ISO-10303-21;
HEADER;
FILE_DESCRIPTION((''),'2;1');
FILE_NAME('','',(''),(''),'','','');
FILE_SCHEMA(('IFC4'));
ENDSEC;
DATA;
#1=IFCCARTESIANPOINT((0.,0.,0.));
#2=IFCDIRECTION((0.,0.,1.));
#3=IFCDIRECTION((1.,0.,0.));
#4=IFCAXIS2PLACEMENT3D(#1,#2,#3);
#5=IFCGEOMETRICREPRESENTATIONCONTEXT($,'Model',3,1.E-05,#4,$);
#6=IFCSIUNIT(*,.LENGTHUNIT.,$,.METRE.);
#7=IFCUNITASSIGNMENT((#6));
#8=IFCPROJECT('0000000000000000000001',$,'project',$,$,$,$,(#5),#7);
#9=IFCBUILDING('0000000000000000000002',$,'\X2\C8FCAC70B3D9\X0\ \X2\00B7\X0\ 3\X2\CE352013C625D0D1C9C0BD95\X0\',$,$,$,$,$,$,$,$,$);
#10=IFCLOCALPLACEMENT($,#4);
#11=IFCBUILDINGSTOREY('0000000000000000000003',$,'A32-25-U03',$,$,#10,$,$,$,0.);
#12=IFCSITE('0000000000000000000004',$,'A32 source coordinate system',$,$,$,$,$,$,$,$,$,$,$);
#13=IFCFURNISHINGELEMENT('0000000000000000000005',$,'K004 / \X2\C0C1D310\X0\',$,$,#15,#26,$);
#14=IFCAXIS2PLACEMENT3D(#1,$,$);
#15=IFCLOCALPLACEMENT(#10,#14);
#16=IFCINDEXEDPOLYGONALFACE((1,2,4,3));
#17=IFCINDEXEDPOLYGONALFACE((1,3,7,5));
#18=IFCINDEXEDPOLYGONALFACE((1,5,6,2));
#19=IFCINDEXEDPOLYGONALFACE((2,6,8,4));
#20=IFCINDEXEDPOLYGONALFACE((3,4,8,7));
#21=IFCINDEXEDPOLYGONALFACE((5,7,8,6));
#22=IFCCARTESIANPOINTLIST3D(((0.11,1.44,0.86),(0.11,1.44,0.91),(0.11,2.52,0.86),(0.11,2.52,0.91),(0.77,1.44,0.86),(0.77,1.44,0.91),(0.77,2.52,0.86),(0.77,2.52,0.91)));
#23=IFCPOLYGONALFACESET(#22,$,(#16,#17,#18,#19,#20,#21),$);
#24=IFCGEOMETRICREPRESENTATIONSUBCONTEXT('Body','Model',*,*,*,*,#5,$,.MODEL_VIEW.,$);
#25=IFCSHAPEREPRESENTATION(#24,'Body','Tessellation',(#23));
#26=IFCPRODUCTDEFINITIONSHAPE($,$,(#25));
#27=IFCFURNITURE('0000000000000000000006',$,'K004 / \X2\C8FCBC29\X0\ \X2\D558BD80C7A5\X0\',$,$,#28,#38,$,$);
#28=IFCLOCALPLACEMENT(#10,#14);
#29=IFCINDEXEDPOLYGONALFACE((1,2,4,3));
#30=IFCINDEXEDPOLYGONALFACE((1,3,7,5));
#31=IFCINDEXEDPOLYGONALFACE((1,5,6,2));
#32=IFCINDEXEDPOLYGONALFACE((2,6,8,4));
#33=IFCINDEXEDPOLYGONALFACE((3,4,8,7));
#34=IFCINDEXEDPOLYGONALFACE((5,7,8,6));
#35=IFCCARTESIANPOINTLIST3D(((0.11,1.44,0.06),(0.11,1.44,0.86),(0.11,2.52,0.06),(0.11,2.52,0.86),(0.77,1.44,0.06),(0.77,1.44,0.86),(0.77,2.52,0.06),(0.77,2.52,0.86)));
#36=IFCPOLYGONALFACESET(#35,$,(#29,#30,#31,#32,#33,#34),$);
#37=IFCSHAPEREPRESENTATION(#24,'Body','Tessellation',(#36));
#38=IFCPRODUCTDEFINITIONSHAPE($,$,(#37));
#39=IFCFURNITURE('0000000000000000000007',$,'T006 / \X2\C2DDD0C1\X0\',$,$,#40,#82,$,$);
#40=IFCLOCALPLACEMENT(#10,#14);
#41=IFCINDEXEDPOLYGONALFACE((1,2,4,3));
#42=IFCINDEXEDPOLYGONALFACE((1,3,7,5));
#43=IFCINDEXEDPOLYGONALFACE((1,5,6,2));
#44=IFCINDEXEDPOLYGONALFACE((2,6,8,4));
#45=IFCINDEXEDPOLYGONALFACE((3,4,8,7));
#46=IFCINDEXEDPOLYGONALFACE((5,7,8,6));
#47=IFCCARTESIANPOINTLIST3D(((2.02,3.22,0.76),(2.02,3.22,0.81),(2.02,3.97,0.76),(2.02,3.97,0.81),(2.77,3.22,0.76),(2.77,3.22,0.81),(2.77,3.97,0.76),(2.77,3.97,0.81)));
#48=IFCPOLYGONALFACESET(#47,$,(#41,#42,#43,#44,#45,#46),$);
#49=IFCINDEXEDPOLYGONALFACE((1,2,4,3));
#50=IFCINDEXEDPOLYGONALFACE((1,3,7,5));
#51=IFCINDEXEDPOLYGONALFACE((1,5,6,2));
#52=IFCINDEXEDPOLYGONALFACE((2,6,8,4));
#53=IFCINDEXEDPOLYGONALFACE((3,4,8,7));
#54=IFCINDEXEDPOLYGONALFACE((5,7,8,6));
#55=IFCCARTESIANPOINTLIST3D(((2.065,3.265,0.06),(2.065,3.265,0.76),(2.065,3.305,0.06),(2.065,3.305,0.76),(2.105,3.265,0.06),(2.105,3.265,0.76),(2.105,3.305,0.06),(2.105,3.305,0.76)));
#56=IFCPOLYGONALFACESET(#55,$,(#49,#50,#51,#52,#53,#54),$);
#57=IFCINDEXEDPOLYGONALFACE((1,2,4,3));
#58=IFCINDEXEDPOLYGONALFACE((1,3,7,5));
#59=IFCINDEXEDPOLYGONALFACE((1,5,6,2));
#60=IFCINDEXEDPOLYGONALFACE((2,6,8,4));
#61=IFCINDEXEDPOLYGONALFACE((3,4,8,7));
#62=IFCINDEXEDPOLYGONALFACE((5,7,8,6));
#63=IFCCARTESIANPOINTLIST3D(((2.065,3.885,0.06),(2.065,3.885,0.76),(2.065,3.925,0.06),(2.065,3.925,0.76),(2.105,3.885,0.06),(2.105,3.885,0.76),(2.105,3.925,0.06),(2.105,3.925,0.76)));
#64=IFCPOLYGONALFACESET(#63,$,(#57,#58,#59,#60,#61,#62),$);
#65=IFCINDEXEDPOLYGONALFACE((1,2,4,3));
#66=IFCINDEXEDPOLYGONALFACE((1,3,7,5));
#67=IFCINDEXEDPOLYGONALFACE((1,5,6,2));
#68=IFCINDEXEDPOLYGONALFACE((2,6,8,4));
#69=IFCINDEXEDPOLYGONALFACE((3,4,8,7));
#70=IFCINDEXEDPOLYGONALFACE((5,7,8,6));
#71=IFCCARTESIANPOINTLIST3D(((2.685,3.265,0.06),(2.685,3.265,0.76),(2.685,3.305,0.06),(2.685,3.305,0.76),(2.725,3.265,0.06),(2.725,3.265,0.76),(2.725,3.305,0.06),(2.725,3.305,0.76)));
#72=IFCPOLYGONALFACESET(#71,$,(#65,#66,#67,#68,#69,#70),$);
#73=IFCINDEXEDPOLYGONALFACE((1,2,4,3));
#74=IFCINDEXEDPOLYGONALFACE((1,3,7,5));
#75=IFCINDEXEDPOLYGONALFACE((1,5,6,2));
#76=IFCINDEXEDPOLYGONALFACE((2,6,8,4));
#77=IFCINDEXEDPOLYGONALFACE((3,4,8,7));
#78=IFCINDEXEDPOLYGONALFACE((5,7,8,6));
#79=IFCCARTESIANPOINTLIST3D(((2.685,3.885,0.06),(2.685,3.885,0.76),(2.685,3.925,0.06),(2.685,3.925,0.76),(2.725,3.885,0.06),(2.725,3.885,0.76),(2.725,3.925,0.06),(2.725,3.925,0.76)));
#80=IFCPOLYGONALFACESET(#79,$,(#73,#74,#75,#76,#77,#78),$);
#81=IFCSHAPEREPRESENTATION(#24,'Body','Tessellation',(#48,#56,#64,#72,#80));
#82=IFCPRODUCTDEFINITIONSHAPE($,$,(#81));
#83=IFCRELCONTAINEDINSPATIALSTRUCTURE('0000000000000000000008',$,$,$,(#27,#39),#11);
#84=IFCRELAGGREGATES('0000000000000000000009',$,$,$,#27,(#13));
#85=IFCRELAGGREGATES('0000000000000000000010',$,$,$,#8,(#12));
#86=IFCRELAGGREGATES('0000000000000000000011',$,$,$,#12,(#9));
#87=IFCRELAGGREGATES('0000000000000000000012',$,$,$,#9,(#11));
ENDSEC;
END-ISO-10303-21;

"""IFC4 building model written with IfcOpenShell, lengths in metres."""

from ifc_helpers import new_model, si_unit, frame, origin_with_axes, place, context, subcontext, project, spatial, polyline, outline, extrude, element, aggregate, save


model = new_model("IFC4")

# Units and contexts
model_context = context("Model", 3, precision=1e-05, world=origin_with_axes())
body_context = subcontext(model_context, "Body", "Model", "MODEL_VIEW")
ifc_project = project(units=[si_unit("LENGTHUNIT", "METRE")], contexts=[model_context])

# Site, building, storey
site = spatial("IfcSite", under=ifc_project, Name="A32 source coordinate system")
building = spatial("IfcBuilding", under=site, Name="주거동 · 3층–옥탑지붕")
storey_placement = place(None, origin_with_axes())
storey = spatial("IfcBuildingStorey", under=building, at=storey_placement, Name="A32-25-U03", Elevation=0.0)

# Furnishing element
furniture_1_placement = place(storey_placement, origin_with_axes())
furnishing_1_placement = place(furniture_1_placement, origin_with_axes())
furnishing_1 = element("IfcFurnishingElement", 1, at=furnishing_1_placement, Name="K004 / 상판", context=body_context, shape_type="SweptSolid", body=[
    extrude(outline(polyline([(0.77, 2.52), (0.77, 1.44), (0.11, 1.44), (0.11, 2.52), (0.77, 2.52)])), frame((0.0, 0.0, 0.86)), (0.0, 0.0, 1.0), 0.05),
])

# Furniture
furniture_1 = element("IfcFurniture", 2, at=furniture_1_placement, inside=storey, Name="K004 / 주방 하부장", context=body_context, shape_type="SweptSolid", body=[
    extrude(outline(polyline([(0.11, 2.52), (0.77, 2.52), (0.77, 1.44), (0.11, 1.44), (0.11, 2.52)])), frame((0.0, 0.0, 0.06)), (0.0, 0.0, 1.0), 0.8),
])
aggregate(furniture_1, [furnishing_1])
furniture_2_placement = place(storey_placement, origin_with_axes())
element("IfcFurniture", 3, at=furniture_2_placement, inside=storey, Name="T006 / 식탁", context=body_context, shape_type="SweptSolid", body=[
    extrude(outline(polyline([(2.77, 3.22), (2.02, 3.22), (2.02, 3.97), (2.77, 3.97), (2.77, 3.22)])), frame((0.0, 0.0, 0.76)), (0.0, 0.0, 1.0), 0.05),
    extrude(outline(polyline([(2.065, 3.265), (2.065, 3.305), (2.105, 3.305), (2.105, 3.265), (2.065, 3.265)])), frame((0.0, 0.0, 0.06)), (0.0, 0.0, 1.0), 0.7),
    extrude(outline(polyline([(2.065, 3.885), (2.065, 3.925), (2.105, 3.925), (2.105, 3.885), (2.065, 3.885)])), frame((0.0, 0.0, 0.06)), (0.0, 0.0, 1.0), 0.7),
    extrude(outline(polyline([(2.685, 3.265), (2.685, 3.305), (2.725, 3.305), (2.725, 3.265), (2.685, 3.265)])), frame((0.0, 0.0, 0.06)), (0.0, 0.0, 1.0), 0.7),
    extrude(outline(polyline([(2.685, 3.885), (2.685, 3.925), (2.725, 3.925), (2.725, 3.885), (2.685, 3.885)])), frame((0.0, 0.0, 0.06)), (0.0, 0.0, 1.0), 0.7),
])

save(model, "model.ifc")
